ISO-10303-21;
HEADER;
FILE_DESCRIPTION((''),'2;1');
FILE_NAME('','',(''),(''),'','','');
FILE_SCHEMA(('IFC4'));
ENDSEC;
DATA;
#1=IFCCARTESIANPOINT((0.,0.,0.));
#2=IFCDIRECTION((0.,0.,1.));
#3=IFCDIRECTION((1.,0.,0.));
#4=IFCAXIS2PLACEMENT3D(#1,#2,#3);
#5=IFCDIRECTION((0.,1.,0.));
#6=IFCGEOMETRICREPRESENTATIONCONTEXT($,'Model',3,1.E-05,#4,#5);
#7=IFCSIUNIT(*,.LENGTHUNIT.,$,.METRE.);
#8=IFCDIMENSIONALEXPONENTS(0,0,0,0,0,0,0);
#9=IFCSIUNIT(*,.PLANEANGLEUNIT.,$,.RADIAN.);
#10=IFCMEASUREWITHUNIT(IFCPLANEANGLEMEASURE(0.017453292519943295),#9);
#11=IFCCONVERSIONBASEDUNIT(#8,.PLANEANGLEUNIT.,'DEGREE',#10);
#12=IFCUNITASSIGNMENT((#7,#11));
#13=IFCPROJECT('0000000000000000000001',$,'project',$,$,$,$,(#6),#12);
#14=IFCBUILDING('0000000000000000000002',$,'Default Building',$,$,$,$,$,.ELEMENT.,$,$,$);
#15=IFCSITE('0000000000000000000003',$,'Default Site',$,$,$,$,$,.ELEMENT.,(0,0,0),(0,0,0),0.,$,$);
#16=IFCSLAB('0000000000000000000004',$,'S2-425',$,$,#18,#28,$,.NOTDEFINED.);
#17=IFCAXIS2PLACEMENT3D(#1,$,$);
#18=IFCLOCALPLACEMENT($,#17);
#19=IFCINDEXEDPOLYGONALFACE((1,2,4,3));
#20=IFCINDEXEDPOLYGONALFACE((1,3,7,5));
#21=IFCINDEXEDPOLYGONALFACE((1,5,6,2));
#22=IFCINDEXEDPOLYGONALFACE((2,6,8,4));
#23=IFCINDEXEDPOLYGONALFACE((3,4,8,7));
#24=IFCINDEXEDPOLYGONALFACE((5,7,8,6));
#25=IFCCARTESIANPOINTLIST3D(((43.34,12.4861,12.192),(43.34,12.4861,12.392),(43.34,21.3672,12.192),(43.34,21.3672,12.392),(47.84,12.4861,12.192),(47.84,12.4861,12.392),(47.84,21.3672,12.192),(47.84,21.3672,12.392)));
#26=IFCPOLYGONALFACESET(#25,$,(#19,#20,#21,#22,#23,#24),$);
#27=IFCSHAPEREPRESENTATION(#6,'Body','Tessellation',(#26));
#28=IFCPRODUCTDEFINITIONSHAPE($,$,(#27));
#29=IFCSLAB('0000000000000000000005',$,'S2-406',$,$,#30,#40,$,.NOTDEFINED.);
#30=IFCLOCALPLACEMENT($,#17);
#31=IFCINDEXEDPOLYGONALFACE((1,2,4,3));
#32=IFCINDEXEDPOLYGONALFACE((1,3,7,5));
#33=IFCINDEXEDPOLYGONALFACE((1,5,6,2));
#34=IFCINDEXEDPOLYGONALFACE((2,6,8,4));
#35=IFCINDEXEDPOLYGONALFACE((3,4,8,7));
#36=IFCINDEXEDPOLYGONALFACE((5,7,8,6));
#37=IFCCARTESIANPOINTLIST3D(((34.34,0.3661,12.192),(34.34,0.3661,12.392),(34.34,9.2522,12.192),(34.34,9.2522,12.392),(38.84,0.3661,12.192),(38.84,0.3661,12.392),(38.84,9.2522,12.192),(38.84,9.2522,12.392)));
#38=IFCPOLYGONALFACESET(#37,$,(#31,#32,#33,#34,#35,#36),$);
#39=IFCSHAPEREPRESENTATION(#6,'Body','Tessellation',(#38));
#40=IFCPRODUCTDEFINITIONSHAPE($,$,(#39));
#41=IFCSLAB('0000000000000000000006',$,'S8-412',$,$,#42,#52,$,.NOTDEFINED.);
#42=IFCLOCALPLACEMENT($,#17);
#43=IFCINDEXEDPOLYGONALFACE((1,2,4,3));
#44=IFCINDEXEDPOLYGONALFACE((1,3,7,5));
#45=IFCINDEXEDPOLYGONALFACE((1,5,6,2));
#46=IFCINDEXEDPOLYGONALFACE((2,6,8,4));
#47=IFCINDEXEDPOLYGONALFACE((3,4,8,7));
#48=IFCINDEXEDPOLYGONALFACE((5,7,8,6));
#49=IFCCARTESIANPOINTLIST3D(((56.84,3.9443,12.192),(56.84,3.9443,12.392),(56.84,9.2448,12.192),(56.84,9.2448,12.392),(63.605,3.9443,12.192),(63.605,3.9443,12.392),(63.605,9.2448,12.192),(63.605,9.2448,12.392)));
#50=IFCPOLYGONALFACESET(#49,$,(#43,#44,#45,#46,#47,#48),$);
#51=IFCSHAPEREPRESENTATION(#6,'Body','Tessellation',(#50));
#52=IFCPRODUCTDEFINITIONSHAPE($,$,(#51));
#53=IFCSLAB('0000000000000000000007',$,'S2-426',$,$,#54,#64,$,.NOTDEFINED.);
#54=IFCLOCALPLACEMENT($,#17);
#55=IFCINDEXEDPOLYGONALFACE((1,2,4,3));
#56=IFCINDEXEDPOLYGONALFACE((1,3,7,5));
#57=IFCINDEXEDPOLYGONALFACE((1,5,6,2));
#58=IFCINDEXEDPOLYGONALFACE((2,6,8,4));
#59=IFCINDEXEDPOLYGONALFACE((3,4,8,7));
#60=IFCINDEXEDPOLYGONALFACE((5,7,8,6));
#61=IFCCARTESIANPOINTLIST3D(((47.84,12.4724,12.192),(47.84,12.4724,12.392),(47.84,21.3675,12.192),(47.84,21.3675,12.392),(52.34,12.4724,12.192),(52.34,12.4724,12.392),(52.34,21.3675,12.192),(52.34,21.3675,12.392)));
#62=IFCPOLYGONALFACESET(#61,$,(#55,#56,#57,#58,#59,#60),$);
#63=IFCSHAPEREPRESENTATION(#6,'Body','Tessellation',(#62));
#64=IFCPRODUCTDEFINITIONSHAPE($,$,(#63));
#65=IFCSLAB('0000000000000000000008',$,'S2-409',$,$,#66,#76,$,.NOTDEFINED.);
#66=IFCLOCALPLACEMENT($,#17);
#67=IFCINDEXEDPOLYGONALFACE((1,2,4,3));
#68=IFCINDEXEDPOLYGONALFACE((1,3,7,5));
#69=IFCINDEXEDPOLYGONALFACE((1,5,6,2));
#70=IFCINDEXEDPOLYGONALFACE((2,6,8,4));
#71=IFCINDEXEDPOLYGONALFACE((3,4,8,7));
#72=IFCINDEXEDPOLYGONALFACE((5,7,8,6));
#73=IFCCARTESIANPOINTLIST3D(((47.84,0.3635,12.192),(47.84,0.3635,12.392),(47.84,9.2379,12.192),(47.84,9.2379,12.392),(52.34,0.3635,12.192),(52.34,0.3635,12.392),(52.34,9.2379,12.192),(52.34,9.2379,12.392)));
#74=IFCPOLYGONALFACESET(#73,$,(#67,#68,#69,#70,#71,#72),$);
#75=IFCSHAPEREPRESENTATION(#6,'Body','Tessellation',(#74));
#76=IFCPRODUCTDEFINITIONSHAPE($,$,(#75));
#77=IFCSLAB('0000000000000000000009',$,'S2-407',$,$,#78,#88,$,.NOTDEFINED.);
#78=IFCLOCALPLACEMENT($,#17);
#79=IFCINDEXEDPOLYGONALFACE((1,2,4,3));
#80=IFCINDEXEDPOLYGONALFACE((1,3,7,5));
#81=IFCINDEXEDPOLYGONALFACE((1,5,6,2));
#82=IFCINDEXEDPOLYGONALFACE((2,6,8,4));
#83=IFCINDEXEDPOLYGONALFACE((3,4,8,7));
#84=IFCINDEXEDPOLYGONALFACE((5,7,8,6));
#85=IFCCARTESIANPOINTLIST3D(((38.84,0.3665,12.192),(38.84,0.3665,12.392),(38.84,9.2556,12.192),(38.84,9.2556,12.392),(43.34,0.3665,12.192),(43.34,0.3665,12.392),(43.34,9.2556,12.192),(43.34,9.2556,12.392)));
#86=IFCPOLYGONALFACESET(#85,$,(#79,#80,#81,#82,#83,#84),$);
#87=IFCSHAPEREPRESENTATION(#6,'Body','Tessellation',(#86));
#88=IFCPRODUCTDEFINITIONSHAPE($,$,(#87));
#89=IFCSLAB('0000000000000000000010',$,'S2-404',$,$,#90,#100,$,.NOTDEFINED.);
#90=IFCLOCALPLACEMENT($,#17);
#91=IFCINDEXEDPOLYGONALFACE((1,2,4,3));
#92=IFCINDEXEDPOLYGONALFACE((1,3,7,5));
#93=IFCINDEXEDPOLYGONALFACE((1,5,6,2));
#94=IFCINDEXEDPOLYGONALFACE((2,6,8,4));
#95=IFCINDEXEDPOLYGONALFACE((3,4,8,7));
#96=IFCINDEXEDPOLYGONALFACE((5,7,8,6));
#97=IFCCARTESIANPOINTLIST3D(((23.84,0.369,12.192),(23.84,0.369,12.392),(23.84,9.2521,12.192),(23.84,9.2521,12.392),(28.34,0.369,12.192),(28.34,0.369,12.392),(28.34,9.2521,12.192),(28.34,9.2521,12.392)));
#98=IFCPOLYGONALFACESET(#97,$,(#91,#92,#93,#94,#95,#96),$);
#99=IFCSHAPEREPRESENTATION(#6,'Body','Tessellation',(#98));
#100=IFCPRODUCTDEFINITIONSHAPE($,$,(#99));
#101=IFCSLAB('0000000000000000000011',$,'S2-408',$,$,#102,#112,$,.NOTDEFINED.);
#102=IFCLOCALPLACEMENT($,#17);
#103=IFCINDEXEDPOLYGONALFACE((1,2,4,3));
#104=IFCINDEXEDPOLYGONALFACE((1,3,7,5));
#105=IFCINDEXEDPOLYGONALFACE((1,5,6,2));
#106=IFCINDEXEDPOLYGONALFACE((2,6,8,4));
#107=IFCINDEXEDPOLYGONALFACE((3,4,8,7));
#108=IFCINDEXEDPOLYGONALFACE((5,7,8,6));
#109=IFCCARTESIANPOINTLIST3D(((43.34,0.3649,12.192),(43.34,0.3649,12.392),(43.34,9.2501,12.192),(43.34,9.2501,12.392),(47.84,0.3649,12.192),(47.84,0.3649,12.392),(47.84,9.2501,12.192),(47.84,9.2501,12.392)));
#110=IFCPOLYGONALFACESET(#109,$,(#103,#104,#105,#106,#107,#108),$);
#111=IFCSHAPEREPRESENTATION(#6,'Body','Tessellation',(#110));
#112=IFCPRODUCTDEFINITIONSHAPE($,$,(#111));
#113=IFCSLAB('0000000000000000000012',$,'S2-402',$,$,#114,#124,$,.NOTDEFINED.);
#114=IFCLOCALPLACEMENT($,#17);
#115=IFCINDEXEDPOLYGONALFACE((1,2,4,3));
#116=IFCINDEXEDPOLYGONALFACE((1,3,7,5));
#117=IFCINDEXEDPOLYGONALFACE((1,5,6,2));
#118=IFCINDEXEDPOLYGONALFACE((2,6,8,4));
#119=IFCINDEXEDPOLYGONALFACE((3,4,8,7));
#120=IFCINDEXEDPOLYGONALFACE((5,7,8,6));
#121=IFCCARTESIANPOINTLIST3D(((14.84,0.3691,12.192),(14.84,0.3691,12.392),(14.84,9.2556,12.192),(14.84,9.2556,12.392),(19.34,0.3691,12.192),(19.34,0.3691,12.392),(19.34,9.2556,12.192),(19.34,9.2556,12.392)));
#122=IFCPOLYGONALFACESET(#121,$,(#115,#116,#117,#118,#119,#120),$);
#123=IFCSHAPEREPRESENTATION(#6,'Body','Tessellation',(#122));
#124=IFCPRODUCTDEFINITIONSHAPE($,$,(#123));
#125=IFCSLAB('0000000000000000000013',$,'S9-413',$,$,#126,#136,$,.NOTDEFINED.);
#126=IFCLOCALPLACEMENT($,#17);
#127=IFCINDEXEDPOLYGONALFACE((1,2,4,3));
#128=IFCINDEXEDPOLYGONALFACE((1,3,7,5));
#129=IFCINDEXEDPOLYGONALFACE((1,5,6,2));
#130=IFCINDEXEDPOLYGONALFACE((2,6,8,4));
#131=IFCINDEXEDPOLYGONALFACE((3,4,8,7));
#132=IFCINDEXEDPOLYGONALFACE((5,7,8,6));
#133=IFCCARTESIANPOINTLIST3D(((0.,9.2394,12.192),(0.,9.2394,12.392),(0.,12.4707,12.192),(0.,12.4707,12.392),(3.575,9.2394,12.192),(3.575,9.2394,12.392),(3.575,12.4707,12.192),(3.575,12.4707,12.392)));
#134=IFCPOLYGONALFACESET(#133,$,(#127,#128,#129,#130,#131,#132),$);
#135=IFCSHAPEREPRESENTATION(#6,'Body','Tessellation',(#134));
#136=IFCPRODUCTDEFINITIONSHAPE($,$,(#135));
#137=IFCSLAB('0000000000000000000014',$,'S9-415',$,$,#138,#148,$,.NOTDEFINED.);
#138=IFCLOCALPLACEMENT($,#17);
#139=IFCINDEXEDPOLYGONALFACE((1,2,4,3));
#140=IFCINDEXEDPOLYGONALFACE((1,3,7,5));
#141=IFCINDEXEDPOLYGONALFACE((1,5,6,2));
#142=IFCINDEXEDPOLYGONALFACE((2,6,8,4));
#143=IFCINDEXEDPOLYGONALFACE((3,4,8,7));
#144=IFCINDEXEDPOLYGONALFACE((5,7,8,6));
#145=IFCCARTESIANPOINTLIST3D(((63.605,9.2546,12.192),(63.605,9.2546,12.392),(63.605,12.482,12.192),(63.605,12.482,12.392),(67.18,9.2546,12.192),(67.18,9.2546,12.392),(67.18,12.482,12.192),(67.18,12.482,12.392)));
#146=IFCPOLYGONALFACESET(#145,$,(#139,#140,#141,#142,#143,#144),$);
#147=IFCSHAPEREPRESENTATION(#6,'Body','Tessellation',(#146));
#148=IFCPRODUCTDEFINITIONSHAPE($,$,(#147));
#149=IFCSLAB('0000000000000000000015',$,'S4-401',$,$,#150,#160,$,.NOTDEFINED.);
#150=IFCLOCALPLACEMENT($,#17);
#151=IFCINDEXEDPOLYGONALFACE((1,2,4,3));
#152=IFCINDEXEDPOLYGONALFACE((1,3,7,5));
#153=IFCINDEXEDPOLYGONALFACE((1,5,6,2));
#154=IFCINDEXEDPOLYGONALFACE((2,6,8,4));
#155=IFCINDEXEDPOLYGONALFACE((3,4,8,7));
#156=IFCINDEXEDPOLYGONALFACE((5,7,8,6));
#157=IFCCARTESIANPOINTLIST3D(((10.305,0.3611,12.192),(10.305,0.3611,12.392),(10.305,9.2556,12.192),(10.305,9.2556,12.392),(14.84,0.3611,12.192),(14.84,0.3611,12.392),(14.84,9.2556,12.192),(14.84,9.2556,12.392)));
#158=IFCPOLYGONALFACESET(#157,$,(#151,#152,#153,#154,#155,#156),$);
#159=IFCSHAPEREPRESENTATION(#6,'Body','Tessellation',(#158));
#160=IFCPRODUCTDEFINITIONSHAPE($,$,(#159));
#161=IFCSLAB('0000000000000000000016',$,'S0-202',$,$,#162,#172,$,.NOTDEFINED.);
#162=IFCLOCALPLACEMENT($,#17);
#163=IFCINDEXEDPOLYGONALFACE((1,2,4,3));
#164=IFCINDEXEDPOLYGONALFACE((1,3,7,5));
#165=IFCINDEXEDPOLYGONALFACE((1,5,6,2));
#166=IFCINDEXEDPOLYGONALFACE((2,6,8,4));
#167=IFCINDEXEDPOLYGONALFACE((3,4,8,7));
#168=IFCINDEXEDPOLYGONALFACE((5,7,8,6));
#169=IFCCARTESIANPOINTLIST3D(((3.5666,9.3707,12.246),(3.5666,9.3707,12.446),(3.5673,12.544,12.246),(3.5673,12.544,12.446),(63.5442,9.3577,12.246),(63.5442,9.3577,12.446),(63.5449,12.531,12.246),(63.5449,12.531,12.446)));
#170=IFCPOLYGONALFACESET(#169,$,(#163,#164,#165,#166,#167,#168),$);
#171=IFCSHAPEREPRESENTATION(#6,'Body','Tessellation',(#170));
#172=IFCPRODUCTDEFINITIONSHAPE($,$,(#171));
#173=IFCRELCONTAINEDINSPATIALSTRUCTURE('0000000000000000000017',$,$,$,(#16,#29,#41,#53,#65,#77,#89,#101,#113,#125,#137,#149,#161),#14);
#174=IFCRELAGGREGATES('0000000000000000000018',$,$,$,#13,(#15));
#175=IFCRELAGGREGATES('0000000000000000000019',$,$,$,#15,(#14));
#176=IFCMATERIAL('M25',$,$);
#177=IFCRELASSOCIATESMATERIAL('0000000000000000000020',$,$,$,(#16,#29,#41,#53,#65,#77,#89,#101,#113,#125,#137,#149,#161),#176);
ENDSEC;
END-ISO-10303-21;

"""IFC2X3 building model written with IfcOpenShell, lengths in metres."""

from ifc_helpers import new_model, entity, si_unit, converted_unit, direction, frame, frame_2d, origin_with_axes, place, context, project, spatial, rectangle, extrude, material, element, save


model = new_model("IFC2X3")

# Units and contexts
model_context = context("Model", 3, precision=1e-05, world=origin_with_axes(), true_north=direction((0.0, 1.0, 0.0)))
ifc_project = project(units=[si_unit("LENGTHUNIT", "METRE"), converted_unit("PLANEANGLEUNIT", "DEGREE", entity("IfcPlaneAngleMeasure", 0.017453292519943295), si_unit("PLANEANGLEUNIT", "RADIAN"), dimensions=[0, 0, 0, 0, 0, 0, 0])], contexts=[model_context])

# Site, building
site = spatial("IfcSite", under=ifc_project, Name="Default Site", CompositionType="ELEMENT", RefLatitude=(0, 0, 0), RefLongitude=(0, 0, 0), RefElevation=0.0)
building = spatial("IfcBuilding", under=site, Name="Default Building", CompositionType="ELEMENT")

# Shared definitions
ifc_material = material(Name="M25")
placement = place(None, origin_with_axes())

# Slabs
element("IfcSlab", 1, at=placement, inside=building, material=ifc_material, Name="S2-425", PredefinedType="NOTDEFINED", context=model_context, shape_type="SweptSolid", body=[
    extrude(rectangle(XDim=4.5, YDim=8.8811, at=frame_2d((0.0, 0.0), x_axis=(1.0, 0.0, 0.0))), frame((45.59, 16.9266, 12.192), z_axis=(0.0, 0.0, 1.0), x_axis=(1.0, 0.0, 0.0)), (0.0, 0.0, 1.0), 0.2),
])
element("IfcSlab", 2, at=placement, inside=building, material=ifc_material, Name="S2-406", PredefinedType="NOTDEFINED", context=model_context, shape_type="SweptSolid", body=[
    extrude(rectangle(XDim=4.5, YDim=8.8861, at=frame_2d((0.0, 0.0), x_axis=(1.0, 0.0, 0.0))), frame((36.59, 4.8092, 12.192), z_axis=(0.0, 0.0, 1.0), x_axis=(1.0, 0.0, 0.0)), (0.0, 0.0, 1.0), 0.2),
])
element("IfcSlab", 3, at=placement, inside=building, material=ifc_material, Name="S8-412", PredefinedType="NOTDEFINED", context=model_context, shape_type="SweptSolid", body=[
    extrude(rectangle(XDim=6.765, YDim=5.3005, at=frame_2d((0.0, 0.0), x_axis=(1.0, 0.0, 0.0))), frame((60.2225, 6.5946, 12.192), z_axis=(0.0, 0.0, 1.0), x_axis=(1.0, 0.0, 0.0)), (0.0, 0.0, 1.0), 0.2),
])
element("IfcSlab", 4, at=placement, inside=building, material=ifc_material, Name="S2-426", PredefinedType="NOTDEFINED", context=model_context, shape_type="SweptSolid", body=[
    extrude(rectangle(XDim=4.5, YDim=8.8951, at=frame_2d((0.0, 0.0), x_axis=(1.0, 0.0, 0.0))), frame((50.09, 16.9199, 12.192), z_axis=(0.0, 0.0, 1.0), x_axis=(1.0, 0.0, 0.0)), (0.0, 0.0, 1.0), 0.2),
])
element("IfcSlab", 5, at=placement, inside=building, material=ifc_material, Name="S2-409", PredefinedType="NOTDEFINED", context=model_context, shape_type="SweptSolid", body=[
    extrude(rectangle(XDim=4.5, YDim=8.8744, at=frame_2d((0.0, 0.0), x_axis=(1.0, 0.0, 0.0))), frame((50.09, 4.8007, 12.192), z_axis=(0.0, 0.0, 1.0), x_axis=(1.0, 0.0, 0.0)), (0.0, 0.0, 1.0), 0.2),
])
element("IfcSlab", 6, at=placement, inside=building, material=ifc_material, Name="S2-407", PredefinedType="NOTDEFINED", context=model_context, shape_type="SweptSolid", body=[
    extrude(rectangle(XDim=4.5, YDim=8.8891, at=frame_2d((0.0, 0.0), x_axis=(1.0, 0.0, 0.0))), frame((41.09, 4.811, 12.192), z_axis=(0.0, 0.0, 1.0), x_axis=(1.0, 0.0, 0.0)), (0.0, 0.0, 1.0), 0.2),
])
element("IfcSlab", 7, at=placement, inside=building, material=ifc_material, Name="S2-404", PredefinedType="NOTDEFINED", context=model_context, shape_type="SweptSolid", body=[
    extrude(rectangle(XDim=4.5, YDim=8.8831, at=frame_2d((0.0, 0.0), x_axis=(1.0, 0.0, 0.0))), frame((26.09, 4.8106, 12.192), z_axis=(0.0, 0.0, 1.0), x_axis=(1.0, 0.0, 0.0)), (0.0, 0.0, 1.0), 0.2),
])
element("IfcSlab", 8, at=placement, inside=building, material=ifc_material, Name="S2-408", PredefinedType="NOTDEFINED", context=model_context, shape_type="SweptSolid", body=[
    extrude(rectangle(XDim=4.5, YDim=8.8852, at=frame_2d((0.0, 0.0), x_axis=(1.0, 0.0, 0.0))), frame((45.59, 4.8075, 12.192), z_axis=(0.0, 0.0, 1.0), x_axis=(1.0, 0.0, 0.0)), (0.0, 0.0, 1.0), 0.2),
])
element("IfcSlab", 9, at=placement, inside=building, material=ifc_material, Name="S2-402", PredefinedType="NOTDEFINED", context=model_context, shape_type="SweptSolid", body=[
    extrude(rectangle(XDim=4.5, YDim=8.8865, at=frame_2d((0.0, 0.0), x_axis=(1.0, 0.0, 0.0))), frame((17.09, 4.8123, 12.192), z_axis=(0.0, 0.0, 1.0), x_axis=(1.0, 0.0, 0.0)), (0.0, 0.0, 1.0), 0.2),
])
element("IfcSlab", 10, at=placement, inside=building, material=ifc_material, Name="S9-413", PredefinedType="NOTDEFINED", context=model_context, shape_type="SweptSolid", body=[
    extrude(rectangle(XDim=3.575, YDim=3.2313, at=frame_2d((0.0, 0.0), x_axis=(1.0, 0.0, 0.0))), frame((1.7875, 10.8551, 12.192), z_axis=(0.0, 0.0, 1.0), x_axis=(1.0, 0.0, 0.0)), (0.0, 0.0, 1.0), 0.2),
])
element("IfcSlab", 11, at=placement, inside=building, material=ifc_material, Name="S9-415", PredefinedType="NOTDEFINED", context=model_context, shape_type="SweptSolid", body=[
    extrude(rectangle(XDim=3.575, YDim=3.2274, at=frame_2d((0.0, 0.0), x_axis=(1.0, 0.0, 0.0))), frame((65.3925, 10.8683, 12.192), z_axis=(0.0, 0.0, 1.0), x_axis=(1.0, 0.0, 0.0)), (0.0, 0.0, 1.0), 0.2),
])
element("IfcSlab", 12, at=placement, inside=building, material=ifc_material, Name="S4-401", PredefinedType="NOTDEFINED", context=model_context, shape_type="SweptSolid", body=[
    extrude(rectangle(XDim=4.535, YDim=8.8945, at=frame_2d((0.0, 0.0), x_axis=(1.0, 0.0, 0.0))), frame((12.5725, 4.8083, 12.192), z_axis=(0.0, 0.0, 1.0), x_axis=(1.0, 0.0, 0.0)), (0.0, 0.0, 1.0), 0.2),
])
element("IfcSlab", 13, at=placement, inside=building, material=ifc_material, Name="S0-202", PredefinedType="NOTDEFINED", context=model_context, shape_type="SweptSolid", body=[
    extrude(rectangle(XDim=3.1733, YDim=59.9776, at=frame_2d((0.0, 0.0), x_axis=(-0.000216, -1.0, 0.0))), frame((33.5558, 10.9509, 12.246), z_axis=(0.0, 0.0, 1.0), x_axis=(1.0, 0.0, 0.0)), (0.0, 0.0, 1.0), 0.2),
])

save(model, "model.ifc")
